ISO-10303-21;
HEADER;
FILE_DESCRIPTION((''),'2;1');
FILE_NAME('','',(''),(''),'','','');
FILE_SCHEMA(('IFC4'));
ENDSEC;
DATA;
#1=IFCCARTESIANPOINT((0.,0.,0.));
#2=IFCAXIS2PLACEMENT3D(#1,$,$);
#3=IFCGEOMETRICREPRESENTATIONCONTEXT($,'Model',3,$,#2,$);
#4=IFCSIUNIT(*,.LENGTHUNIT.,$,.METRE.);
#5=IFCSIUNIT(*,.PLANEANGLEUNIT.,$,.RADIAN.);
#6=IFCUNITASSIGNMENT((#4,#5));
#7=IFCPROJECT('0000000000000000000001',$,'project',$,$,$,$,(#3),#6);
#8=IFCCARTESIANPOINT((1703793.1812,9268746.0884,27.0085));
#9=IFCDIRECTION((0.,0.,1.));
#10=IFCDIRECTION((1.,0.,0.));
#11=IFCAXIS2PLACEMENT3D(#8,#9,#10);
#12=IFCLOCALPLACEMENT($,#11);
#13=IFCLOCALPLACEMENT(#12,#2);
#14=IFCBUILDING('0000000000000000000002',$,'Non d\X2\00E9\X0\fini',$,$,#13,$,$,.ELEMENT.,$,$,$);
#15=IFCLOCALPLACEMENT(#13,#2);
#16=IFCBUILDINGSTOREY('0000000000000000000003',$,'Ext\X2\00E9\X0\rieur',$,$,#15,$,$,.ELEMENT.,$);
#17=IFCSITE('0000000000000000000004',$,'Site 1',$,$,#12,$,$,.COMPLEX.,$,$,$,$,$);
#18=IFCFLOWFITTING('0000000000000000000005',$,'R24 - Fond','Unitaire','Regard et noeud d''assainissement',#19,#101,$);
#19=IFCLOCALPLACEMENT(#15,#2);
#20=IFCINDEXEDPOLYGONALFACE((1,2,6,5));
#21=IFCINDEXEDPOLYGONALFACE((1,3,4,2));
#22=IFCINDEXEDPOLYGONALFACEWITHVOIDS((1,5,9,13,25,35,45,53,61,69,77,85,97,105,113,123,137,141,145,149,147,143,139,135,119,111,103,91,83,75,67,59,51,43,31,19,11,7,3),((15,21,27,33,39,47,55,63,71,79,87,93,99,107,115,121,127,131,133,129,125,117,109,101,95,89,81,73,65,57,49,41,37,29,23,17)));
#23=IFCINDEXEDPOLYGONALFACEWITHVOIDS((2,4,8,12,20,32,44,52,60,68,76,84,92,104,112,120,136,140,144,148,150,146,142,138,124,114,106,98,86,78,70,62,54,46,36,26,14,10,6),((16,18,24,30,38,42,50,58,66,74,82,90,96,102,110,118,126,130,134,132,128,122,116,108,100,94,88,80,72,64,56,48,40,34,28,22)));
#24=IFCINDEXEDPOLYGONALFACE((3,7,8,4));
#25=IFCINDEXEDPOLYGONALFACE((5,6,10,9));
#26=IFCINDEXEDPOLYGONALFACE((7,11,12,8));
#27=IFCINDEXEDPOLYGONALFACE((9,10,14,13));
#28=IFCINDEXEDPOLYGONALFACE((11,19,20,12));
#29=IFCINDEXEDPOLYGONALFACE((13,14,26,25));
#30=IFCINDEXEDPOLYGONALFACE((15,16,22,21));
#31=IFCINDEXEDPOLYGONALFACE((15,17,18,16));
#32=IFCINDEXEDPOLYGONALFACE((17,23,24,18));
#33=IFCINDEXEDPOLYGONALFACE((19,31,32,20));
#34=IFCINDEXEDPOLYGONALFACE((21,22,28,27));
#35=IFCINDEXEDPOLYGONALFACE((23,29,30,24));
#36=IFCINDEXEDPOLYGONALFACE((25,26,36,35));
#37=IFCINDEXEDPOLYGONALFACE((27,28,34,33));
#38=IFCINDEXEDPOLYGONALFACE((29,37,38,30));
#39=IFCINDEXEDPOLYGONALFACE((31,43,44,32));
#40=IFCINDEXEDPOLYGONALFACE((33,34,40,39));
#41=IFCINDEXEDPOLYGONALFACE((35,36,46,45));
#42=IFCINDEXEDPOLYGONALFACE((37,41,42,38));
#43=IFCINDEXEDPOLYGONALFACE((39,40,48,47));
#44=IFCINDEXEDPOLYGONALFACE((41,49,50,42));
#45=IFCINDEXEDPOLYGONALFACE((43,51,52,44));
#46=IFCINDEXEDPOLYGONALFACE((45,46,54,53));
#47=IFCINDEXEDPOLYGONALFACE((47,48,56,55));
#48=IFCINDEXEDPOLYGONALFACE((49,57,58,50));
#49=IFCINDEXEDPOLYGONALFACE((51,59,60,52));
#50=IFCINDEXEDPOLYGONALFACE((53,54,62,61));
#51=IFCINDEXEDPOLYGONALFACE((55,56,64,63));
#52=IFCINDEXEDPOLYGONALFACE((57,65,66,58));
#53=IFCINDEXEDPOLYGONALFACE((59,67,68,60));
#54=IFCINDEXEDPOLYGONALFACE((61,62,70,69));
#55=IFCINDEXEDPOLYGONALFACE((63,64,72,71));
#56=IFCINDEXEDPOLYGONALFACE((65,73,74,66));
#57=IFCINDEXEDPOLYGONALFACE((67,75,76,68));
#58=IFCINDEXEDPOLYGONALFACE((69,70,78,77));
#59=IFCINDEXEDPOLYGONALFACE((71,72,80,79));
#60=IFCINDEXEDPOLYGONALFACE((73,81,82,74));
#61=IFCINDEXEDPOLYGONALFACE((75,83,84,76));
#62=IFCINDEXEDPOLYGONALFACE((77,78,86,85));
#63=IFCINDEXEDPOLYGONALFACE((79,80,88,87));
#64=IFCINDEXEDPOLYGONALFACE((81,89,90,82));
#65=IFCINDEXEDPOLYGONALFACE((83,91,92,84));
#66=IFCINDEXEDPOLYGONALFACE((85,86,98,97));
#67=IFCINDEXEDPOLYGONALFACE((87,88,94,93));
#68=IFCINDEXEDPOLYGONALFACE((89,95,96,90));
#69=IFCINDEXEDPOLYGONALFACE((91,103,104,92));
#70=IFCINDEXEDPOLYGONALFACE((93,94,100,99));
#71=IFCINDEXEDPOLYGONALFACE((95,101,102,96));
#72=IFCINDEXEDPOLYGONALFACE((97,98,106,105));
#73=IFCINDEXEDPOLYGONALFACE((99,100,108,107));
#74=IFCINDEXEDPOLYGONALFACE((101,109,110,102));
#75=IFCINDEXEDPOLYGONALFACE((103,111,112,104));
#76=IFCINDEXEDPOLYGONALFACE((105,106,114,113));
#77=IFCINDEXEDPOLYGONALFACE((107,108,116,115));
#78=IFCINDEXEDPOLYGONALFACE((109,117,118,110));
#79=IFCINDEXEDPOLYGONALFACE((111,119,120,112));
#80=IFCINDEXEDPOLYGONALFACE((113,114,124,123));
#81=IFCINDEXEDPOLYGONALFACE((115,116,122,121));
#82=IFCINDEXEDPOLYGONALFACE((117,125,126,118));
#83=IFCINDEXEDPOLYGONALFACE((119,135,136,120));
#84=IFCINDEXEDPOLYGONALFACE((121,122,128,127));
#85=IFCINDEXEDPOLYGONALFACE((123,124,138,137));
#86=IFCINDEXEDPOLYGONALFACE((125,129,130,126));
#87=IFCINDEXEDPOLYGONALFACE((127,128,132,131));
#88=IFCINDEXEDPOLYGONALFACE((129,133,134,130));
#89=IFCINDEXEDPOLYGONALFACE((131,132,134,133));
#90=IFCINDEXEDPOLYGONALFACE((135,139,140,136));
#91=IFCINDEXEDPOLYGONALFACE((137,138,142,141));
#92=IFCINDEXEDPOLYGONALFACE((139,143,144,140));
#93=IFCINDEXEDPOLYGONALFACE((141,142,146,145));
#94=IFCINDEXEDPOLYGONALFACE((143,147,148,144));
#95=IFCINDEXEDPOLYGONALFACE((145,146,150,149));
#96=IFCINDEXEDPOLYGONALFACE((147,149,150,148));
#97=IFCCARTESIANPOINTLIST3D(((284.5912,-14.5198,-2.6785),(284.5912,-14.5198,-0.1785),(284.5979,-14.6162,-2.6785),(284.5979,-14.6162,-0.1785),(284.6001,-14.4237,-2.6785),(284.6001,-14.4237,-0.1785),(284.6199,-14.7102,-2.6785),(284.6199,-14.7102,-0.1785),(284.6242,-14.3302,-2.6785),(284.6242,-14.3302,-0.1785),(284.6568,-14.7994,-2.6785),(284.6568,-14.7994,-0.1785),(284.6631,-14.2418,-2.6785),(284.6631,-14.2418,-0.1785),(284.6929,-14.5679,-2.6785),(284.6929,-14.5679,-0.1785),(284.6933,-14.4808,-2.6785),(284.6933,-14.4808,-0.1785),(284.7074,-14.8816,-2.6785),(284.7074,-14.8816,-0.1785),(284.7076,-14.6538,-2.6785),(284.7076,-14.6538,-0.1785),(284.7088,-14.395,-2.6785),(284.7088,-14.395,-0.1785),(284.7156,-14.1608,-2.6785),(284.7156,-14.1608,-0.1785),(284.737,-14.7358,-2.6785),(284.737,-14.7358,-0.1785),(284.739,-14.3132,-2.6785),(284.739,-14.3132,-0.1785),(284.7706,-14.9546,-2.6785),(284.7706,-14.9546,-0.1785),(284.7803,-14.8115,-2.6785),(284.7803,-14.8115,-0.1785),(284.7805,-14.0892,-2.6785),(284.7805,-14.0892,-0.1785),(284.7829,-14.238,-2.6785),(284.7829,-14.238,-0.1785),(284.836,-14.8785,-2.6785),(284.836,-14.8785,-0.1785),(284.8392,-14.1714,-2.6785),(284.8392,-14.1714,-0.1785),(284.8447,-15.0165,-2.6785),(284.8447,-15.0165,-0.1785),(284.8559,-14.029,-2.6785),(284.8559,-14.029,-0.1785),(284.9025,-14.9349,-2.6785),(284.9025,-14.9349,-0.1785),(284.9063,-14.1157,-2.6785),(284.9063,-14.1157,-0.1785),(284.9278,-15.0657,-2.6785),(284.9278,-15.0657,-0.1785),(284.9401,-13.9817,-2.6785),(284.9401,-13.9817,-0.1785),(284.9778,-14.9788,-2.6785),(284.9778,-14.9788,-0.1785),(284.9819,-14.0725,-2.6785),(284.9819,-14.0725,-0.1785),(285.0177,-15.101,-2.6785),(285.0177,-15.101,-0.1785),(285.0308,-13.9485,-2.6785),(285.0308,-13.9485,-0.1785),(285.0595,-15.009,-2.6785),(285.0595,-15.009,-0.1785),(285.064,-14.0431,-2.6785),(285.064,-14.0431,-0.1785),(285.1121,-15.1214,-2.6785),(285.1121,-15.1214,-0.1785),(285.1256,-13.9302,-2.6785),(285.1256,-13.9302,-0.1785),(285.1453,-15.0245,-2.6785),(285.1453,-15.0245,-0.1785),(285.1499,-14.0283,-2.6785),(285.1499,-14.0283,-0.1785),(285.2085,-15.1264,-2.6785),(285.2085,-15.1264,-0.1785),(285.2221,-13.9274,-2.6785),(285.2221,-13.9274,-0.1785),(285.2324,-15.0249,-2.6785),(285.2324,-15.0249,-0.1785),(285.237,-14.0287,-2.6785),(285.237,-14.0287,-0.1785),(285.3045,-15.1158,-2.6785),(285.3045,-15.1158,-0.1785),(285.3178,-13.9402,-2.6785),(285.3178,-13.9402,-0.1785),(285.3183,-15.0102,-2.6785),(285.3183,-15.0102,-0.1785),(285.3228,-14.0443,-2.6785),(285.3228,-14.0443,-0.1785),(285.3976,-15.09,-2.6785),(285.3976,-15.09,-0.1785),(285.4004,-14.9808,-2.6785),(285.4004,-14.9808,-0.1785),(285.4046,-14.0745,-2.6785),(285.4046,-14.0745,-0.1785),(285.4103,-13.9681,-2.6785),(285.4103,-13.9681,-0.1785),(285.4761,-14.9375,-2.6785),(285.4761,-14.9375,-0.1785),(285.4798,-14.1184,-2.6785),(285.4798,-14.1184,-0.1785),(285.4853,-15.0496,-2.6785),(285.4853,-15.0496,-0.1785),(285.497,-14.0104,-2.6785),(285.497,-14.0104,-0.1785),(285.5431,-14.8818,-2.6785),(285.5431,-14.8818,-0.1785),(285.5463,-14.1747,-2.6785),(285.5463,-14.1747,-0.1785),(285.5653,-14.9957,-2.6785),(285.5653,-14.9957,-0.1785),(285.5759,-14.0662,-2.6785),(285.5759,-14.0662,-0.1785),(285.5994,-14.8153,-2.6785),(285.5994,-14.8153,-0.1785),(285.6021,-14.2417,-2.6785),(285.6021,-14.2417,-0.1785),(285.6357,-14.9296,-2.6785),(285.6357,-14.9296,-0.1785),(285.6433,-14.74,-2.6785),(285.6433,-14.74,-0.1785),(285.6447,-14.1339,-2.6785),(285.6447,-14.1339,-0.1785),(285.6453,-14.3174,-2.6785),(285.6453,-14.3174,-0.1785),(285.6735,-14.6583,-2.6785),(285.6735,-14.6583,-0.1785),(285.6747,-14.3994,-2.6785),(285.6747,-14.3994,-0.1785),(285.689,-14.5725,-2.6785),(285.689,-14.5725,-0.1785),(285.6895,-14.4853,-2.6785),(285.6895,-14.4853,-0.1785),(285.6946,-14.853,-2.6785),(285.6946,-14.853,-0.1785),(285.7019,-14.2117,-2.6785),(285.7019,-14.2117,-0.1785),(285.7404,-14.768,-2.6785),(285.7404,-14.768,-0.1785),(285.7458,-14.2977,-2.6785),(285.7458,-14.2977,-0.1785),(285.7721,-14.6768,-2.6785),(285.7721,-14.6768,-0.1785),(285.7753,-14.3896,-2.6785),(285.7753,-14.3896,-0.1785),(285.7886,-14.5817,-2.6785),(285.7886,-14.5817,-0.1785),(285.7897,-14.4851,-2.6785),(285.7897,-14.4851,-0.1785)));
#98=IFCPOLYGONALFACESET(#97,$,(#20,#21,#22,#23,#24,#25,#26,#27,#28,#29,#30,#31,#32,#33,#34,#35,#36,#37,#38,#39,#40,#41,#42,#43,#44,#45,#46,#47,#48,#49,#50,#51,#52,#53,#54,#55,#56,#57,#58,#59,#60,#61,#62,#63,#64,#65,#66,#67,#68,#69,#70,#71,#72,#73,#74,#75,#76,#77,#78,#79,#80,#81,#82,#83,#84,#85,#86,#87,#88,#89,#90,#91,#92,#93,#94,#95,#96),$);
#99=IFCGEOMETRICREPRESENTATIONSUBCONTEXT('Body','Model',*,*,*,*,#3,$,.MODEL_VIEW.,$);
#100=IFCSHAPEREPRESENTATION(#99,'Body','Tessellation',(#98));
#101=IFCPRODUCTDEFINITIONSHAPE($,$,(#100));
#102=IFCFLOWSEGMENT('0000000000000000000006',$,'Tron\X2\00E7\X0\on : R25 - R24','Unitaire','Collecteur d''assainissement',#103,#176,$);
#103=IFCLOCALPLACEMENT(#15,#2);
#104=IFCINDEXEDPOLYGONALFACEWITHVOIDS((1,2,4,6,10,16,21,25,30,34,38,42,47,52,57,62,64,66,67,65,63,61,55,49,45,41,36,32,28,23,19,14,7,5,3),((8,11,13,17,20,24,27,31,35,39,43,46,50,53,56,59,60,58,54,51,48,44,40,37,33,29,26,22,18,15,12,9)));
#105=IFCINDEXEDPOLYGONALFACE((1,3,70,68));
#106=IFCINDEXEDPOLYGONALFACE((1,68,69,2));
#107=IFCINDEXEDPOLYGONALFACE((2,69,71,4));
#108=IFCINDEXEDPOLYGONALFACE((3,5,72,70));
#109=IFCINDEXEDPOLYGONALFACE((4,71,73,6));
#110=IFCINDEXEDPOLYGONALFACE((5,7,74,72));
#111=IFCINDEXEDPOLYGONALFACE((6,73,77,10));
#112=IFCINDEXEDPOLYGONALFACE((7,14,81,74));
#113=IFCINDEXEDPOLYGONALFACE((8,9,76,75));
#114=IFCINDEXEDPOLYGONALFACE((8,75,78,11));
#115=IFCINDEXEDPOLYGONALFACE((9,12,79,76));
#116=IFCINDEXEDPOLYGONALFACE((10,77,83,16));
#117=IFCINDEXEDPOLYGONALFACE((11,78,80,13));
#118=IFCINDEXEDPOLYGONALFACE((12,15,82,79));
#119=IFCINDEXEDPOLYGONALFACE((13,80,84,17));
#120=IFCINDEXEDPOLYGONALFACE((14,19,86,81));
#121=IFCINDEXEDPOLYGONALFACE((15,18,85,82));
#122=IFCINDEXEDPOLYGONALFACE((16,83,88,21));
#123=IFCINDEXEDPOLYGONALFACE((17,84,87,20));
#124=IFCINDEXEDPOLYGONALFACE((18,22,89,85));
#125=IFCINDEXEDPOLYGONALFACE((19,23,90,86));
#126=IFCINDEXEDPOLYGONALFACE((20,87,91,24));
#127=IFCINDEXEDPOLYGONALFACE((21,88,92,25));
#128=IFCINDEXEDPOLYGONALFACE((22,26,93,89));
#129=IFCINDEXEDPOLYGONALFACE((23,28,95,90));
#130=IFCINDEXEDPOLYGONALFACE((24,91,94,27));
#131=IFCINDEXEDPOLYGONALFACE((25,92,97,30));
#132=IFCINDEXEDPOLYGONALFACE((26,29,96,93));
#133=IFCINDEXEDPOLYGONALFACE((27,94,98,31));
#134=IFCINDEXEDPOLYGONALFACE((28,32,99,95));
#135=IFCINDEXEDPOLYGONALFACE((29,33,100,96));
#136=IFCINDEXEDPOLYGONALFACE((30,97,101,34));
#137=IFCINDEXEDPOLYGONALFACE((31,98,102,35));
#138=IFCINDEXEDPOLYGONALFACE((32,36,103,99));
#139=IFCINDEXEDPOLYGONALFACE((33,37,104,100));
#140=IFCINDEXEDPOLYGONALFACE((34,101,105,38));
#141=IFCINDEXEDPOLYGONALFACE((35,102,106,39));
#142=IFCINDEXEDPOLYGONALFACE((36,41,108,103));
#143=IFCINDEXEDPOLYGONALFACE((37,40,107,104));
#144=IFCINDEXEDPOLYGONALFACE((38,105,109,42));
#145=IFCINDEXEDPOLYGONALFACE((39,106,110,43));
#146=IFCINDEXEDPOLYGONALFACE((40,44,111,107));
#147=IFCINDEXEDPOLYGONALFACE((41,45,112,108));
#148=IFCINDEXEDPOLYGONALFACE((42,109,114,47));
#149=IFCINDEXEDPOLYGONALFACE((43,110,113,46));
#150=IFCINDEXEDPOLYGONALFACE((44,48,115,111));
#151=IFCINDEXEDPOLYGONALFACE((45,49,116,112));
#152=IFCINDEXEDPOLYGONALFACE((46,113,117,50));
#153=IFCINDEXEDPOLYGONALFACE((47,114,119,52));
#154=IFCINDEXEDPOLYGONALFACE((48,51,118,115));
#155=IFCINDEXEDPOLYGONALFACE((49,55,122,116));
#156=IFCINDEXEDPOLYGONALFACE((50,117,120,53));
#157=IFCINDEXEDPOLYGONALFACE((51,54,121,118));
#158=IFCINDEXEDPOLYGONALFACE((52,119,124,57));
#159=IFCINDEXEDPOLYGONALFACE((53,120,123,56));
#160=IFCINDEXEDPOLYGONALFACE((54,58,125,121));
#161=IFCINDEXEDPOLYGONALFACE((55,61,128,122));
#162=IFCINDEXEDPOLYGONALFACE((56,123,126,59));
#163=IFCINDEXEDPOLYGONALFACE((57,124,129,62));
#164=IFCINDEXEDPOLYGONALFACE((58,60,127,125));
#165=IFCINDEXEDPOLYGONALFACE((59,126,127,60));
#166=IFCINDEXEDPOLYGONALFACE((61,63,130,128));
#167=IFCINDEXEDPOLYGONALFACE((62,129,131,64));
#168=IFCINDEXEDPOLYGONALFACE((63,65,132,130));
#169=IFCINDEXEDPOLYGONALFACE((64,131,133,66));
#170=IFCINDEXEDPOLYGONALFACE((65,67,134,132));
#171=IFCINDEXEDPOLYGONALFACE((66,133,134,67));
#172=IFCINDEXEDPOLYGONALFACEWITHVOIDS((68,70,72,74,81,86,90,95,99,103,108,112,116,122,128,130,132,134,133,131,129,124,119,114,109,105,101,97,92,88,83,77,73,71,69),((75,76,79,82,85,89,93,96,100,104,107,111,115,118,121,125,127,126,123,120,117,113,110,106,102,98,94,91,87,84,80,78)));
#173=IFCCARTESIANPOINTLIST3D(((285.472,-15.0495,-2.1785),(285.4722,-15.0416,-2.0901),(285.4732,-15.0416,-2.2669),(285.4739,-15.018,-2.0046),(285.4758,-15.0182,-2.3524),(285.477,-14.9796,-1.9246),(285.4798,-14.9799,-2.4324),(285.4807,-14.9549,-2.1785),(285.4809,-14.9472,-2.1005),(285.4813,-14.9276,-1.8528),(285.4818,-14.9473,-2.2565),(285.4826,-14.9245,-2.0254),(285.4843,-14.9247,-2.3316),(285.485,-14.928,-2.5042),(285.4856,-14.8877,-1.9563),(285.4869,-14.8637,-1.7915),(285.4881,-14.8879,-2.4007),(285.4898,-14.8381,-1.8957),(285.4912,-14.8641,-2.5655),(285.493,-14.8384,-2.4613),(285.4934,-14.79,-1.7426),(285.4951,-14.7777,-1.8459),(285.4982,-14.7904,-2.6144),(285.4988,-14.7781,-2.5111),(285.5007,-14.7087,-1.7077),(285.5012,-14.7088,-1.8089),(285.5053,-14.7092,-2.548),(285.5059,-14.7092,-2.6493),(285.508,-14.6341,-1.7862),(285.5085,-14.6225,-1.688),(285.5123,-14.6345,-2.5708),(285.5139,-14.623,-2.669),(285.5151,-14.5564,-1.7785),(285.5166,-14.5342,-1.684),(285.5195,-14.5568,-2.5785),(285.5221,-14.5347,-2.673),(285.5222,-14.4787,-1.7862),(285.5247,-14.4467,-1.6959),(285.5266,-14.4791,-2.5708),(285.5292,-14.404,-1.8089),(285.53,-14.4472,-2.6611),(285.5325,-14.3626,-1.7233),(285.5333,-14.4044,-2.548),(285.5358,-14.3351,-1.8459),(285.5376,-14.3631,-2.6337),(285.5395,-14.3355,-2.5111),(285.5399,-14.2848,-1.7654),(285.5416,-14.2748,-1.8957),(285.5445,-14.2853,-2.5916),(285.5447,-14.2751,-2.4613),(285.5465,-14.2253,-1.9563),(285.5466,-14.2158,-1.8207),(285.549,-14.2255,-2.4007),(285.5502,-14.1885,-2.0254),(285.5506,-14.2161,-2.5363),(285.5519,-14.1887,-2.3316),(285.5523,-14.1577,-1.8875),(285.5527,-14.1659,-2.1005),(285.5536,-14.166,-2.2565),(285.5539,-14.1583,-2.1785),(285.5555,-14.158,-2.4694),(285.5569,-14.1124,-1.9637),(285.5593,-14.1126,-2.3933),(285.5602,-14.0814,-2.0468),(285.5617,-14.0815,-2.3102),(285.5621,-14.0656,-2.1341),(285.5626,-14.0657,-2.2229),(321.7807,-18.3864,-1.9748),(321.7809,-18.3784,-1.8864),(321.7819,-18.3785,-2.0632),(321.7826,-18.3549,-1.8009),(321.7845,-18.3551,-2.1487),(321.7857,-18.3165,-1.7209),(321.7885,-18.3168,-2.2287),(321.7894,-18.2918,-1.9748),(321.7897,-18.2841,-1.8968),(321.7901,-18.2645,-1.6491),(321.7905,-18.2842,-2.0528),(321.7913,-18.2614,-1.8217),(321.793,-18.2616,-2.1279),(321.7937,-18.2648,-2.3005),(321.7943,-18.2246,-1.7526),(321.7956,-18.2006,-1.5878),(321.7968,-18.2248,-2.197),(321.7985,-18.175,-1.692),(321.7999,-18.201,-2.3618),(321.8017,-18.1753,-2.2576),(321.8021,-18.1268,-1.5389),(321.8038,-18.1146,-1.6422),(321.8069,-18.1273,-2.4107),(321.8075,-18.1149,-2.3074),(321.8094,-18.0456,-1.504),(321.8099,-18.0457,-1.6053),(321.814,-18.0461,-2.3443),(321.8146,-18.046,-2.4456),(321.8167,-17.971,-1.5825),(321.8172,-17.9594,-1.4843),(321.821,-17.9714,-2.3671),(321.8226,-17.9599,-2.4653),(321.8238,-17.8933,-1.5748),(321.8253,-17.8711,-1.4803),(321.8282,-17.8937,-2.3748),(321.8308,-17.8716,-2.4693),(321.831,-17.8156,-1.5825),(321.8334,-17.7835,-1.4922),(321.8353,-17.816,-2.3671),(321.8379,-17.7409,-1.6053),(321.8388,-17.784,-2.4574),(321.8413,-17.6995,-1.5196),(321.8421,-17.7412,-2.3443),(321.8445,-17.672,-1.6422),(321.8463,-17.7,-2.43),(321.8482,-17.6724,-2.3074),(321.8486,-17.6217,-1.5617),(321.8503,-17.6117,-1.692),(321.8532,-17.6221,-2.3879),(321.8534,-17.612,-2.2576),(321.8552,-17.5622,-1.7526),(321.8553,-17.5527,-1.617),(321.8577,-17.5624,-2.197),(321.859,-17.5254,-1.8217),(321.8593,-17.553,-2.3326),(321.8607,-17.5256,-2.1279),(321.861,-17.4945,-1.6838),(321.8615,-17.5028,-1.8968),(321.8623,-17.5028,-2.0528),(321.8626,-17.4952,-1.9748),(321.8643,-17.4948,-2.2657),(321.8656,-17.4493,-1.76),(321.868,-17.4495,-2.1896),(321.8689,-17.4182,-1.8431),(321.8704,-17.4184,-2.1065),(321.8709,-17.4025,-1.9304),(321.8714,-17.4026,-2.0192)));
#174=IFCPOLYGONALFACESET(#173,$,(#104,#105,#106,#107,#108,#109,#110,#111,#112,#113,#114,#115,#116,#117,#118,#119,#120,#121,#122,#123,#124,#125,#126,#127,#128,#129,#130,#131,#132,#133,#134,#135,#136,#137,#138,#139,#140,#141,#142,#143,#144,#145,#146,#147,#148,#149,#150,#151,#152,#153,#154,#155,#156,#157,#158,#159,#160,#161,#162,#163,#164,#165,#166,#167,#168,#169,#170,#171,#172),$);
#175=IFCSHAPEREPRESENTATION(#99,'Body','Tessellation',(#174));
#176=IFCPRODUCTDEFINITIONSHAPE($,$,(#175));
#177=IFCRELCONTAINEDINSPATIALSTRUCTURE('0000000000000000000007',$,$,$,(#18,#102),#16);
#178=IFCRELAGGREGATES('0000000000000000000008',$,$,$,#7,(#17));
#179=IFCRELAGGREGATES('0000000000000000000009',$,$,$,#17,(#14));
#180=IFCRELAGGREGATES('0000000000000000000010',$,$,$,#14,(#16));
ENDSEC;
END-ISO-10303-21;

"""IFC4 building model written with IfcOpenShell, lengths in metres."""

from ifc_helpers import new_model, si_unit, frame, origin, origin_2d, place, context, subcontext, project, spatial, hollow_circle, extrude, element, save


model = new_model("IFC4")

# Units and contexts
model_context = context("Model", 3, world=origin())
body_context = subcontext(model_context, "Body", "Model", "MODEL_VIEW")
ifc_project = project(units=[si_unit("LENGTHUNIT", "METRE"), si_unit("PLANEANGLEUNIT", "RADIAN")], contexts=[model_context])

# Site, building, storey
site_placement = place(None, frame((1703793.1812, 9268746.0884, 27.0085), z_axis=(0.0, 0.0, 1.0), x_axis=(1.0, 0.0, 0.0)))
site = spatial("IfcSite", under=ifc_project, at=site_placement, Name="Site 1", CompositionType="COMPLEX")
building_placement = place(site_placement, origin())
building = spatial("IfcBuilding", under=site, at=building_placement, Name="Non défini", CompositionType="ELEMENT")
storey_placement = place(building_placement, origin())
storey = spatial("IfcBuildingStorey", under=building, at=storey_placement, Name="Extérieur", CompositionType="ELEMENT")

# Flow fitting
flow_fitting_1_placement = place(storey_placement, origin())
element("IfcFlowFitting", 1, at=flow_fitting_1_placement, inside=storey, Name="R24 - Fond", Description="Unitaire", ObjectType="Regard et noeud d'assainissement", context=body_context, shape_type="SweptSolid", body=[
    extrude(hollow_circle(Radius=0.6, WallThickness=0.1, at=origin_2d()), frame((285.1912, -14.5266, -2.6785), z_axis=(0.0, 0.0, 1.0), x_axis=(0.995782, -0.091753, 0.0)), (0.0, 0.0, 1.0), 2.5),
])

# Flow segment
flow_segment_1_placement = place(storey_placement, origin())
element("IfcFlowSegment", 2, at=flow_segment_1_placement, inside=storey, Name="Tronçon : R25 - R24", Description="Unitaire", ObjectType="Collecteur d'assainissement", context=body_context, shape_type="SweptSolid", body=[
    extrude(hollow_circle(Radius=0.495, WallThickness=0.095, at=origin_2d()), frame((321.826, -17.8935, -1.9748), z_axis=(-0.995788, 0.091516, -0.005586), x_axis=(-0.091517, -0.995803, 0.0)), (0.0, 0.0, 1.0), 36.4623),
])

save(model, "model.ifc")
